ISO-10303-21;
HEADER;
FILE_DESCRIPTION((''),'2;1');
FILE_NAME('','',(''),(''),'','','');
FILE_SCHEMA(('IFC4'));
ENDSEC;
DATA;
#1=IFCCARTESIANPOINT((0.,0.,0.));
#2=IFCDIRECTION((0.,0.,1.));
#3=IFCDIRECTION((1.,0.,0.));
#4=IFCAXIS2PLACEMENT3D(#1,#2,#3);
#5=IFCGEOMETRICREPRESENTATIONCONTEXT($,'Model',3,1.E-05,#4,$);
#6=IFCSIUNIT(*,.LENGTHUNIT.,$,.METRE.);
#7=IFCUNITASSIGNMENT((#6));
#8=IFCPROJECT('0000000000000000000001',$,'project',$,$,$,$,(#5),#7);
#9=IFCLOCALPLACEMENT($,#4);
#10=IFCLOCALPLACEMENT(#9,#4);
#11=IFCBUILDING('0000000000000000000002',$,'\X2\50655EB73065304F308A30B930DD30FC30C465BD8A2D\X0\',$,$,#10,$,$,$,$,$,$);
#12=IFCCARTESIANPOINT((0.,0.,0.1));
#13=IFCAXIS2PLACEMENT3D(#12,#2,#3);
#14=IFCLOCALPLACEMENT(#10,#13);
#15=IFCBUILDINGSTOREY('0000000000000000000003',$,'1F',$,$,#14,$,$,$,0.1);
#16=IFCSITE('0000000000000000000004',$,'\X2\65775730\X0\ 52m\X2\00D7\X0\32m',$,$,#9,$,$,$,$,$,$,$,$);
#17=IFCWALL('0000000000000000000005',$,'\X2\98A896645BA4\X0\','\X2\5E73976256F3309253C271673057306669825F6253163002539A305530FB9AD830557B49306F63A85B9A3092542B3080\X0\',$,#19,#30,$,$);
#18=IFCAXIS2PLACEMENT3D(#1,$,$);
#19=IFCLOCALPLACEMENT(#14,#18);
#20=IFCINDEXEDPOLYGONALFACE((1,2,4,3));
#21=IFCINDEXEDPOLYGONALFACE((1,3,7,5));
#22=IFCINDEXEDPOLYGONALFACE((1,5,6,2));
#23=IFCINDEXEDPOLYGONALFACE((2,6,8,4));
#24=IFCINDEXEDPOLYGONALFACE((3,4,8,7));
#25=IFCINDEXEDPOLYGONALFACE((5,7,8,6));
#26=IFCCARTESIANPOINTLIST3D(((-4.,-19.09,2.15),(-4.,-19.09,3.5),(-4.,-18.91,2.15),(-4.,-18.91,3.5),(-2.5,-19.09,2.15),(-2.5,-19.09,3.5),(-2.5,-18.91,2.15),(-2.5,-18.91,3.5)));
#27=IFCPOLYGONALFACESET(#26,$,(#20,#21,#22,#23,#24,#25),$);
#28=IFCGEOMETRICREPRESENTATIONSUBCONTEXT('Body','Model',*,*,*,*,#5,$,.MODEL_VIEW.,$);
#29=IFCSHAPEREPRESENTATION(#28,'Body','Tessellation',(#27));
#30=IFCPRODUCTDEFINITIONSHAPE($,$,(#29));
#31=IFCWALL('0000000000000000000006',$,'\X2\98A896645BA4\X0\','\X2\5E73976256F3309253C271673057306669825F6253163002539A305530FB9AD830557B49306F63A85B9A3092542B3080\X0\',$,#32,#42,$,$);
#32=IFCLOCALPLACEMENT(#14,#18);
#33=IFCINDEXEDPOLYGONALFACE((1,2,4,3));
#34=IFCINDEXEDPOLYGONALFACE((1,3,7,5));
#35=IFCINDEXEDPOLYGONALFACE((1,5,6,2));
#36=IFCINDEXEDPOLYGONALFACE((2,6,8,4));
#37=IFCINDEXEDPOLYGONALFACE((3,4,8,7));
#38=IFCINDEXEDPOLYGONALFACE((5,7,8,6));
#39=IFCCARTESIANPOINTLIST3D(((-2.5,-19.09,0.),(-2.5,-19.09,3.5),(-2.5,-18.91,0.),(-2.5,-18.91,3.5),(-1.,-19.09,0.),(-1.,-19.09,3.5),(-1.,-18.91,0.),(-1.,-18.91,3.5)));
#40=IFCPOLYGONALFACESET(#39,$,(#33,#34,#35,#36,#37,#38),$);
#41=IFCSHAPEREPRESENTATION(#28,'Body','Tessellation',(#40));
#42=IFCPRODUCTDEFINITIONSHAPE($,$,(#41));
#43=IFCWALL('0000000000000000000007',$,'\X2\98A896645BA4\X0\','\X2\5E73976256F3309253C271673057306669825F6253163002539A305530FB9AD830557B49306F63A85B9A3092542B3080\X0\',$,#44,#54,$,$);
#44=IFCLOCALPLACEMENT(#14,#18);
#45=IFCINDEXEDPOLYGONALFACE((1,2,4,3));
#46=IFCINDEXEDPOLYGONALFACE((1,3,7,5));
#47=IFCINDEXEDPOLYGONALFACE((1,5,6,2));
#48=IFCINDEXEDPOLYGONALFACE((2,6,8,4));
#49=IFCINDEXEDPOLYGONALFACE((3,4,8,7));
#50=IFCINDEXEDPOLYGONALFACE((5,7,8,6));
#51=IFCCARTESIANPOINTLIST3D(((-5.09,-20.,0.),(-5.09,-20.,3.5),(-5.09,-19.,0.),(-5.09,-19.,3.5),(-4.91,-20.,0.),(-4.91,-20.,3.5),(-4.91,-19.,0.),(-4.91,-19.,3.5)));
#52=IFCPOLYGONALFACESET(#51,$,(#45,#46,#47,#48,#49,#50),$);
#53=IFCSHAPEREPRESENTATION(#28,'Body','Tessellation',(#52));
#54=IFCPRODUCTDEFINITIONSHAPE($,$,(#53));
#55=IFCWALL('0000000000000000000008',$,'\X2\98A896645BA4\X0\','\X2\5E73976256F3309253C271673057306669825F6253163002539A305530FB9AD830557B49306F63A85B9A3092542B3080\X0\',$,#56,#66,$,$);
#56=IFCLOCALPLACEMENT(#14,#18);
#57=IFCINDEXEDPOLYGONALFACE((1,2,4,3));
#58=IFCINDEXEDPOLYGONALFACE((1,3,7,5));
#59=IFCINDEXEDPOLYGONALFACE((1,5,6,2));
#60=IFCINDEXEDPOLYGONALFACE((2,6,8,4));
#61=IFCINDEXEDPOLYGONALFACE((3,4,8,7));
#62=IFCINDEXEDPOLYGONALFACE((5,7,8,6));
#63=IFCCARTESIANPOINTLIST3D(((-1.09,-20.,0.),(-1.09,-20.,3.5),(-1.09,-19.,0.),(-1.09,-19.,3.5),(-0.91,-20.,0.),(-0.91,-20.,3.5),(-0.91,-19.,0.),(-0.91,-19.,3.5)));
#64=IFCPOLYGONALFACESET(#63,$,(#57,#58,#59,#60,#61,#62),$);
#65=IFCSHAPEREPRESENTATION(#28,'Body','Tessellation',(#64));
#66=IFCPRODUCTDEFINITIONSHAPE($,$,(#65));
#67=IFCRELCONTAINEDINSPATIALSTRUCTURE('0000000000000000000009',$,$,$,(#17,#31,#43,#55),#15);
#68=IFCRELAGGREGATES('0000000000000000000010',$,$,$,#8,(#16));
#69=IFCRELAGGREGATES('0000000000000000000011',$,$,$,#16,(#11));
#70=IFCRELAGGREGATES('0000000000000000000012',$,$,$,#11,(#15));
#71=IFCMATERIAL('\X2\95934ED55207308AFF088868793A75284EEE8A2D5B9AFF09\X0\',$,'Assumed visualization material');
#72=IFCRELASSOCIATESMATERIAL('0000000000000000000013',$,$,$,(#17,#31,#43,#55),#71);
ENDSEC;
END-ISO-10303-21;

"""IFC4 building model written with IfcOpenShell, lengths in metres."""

from ifc_helpers import new_model, si_unit, frame, origin_with_axes, place, context, subcontext, project, spatial, rectangle, extrude, material, element, save


model = new_model("IFC4")

# Units and contexts
model_context = context("Model", 3, precision=1e-05, world=origin_with_axes())
body_context = subcontext(model_context, "Body", "Model", "MODEL_VIEW")
ifc_project = project(units=[si_unit("LENGTHUNIT", "METRE")], contexts=[model_context])

# Site, building, storey
site_placement = place(None, origin_with_axes())
site = spatial("IfcSite", under=ifc_project, at=site_placement, Name="敷地 52m×32m")
building_placement = place(site_placement, origin_with_axes())
building = spatial("IfcBuilding", under=site, at=building_placement, Name="健康づくりスポーツ施設")
storey_placement = place(building_placement, frame((0.0, 0.0, 0.1), z_axis=(0.0, 0.0, 1.0), x_axis=(1.0, 0.0, 0.0)))
storey = spatial("IfcBuildingStorey", under=building, at=storey_placement, Name="1F", Elevation=0.1)

# Walls
ifc_material_1 = material(Name="間仕切り（表示用仮設定）", Category="Assumed visualization material")
wall_1_placement = place(storey_placement, frame((-3.25, -19.0, 2.15), z_axis=(0.0, 0.0, 1.0), x_axis=(1.0, 0.0, 0.0)))
element("IfcWall", 1, at=wall_1_placement, inside=storey, material=ifc_material_1, Name="風除室", Description="平面図を参照して概形化。厚さ・高さ等は推定を含む", context=body_context, shape_type="SweptSolid", body=[
    extrude(rectangle(XDim=1.5, YDim=0.18), origin_with_axes(), (0.0, 0.0, 1.0), 1.35),
])
wall_2_placement = place(storey_placement, frame((-1.75, -19.0, 0.0), z_axis=(0.0, 0.0, 1.0), x_axis=(1.0, 0.0, 0.0)))
element("IfcWall", 2, at=wall_2_placement, inside=storey, material=ifc_material_1, Name="風除室", Description="平面図を参照して概形化。厚さ・高さ等は推定を含む", context=body_context, shape_type="SweptSolid", body=[
    extrude(rectangle(XDim=1.5, YDim=0.18), origin_with_axes(), (0.0, 0.0, 1.0), 3.5),
])
for number, where, z_axis, x_axis, name in (
    (3, (-5.0, -19.5, 0.0), (0.0, 0.0, 1.0), (1.0, 0.0, 0.0), "風除室"),
    (4, (-1.0, -19.5, 0.0), (0.0, 0.0, 1.0), (1.0, 0.0, 0.0), "風除室"),
):
    element("IfcWall", number, at=place(storey_placement, frame(where, z_axis=z_axis, x_axis=x_axis)), inside=storey, material=ifc_material_1, Name=name, Description="平面図を参照して概形化。厚さ・高さ等は推定を含む", context=body_context, shape_type="SweptSolid", body=[
        extrude(rectangle(XDim=0.18, YDim=1.0), origin_with_axes(), (0.0, 0.0, 1.0), 3.5),
    ])

save(model, "model.ifc")
